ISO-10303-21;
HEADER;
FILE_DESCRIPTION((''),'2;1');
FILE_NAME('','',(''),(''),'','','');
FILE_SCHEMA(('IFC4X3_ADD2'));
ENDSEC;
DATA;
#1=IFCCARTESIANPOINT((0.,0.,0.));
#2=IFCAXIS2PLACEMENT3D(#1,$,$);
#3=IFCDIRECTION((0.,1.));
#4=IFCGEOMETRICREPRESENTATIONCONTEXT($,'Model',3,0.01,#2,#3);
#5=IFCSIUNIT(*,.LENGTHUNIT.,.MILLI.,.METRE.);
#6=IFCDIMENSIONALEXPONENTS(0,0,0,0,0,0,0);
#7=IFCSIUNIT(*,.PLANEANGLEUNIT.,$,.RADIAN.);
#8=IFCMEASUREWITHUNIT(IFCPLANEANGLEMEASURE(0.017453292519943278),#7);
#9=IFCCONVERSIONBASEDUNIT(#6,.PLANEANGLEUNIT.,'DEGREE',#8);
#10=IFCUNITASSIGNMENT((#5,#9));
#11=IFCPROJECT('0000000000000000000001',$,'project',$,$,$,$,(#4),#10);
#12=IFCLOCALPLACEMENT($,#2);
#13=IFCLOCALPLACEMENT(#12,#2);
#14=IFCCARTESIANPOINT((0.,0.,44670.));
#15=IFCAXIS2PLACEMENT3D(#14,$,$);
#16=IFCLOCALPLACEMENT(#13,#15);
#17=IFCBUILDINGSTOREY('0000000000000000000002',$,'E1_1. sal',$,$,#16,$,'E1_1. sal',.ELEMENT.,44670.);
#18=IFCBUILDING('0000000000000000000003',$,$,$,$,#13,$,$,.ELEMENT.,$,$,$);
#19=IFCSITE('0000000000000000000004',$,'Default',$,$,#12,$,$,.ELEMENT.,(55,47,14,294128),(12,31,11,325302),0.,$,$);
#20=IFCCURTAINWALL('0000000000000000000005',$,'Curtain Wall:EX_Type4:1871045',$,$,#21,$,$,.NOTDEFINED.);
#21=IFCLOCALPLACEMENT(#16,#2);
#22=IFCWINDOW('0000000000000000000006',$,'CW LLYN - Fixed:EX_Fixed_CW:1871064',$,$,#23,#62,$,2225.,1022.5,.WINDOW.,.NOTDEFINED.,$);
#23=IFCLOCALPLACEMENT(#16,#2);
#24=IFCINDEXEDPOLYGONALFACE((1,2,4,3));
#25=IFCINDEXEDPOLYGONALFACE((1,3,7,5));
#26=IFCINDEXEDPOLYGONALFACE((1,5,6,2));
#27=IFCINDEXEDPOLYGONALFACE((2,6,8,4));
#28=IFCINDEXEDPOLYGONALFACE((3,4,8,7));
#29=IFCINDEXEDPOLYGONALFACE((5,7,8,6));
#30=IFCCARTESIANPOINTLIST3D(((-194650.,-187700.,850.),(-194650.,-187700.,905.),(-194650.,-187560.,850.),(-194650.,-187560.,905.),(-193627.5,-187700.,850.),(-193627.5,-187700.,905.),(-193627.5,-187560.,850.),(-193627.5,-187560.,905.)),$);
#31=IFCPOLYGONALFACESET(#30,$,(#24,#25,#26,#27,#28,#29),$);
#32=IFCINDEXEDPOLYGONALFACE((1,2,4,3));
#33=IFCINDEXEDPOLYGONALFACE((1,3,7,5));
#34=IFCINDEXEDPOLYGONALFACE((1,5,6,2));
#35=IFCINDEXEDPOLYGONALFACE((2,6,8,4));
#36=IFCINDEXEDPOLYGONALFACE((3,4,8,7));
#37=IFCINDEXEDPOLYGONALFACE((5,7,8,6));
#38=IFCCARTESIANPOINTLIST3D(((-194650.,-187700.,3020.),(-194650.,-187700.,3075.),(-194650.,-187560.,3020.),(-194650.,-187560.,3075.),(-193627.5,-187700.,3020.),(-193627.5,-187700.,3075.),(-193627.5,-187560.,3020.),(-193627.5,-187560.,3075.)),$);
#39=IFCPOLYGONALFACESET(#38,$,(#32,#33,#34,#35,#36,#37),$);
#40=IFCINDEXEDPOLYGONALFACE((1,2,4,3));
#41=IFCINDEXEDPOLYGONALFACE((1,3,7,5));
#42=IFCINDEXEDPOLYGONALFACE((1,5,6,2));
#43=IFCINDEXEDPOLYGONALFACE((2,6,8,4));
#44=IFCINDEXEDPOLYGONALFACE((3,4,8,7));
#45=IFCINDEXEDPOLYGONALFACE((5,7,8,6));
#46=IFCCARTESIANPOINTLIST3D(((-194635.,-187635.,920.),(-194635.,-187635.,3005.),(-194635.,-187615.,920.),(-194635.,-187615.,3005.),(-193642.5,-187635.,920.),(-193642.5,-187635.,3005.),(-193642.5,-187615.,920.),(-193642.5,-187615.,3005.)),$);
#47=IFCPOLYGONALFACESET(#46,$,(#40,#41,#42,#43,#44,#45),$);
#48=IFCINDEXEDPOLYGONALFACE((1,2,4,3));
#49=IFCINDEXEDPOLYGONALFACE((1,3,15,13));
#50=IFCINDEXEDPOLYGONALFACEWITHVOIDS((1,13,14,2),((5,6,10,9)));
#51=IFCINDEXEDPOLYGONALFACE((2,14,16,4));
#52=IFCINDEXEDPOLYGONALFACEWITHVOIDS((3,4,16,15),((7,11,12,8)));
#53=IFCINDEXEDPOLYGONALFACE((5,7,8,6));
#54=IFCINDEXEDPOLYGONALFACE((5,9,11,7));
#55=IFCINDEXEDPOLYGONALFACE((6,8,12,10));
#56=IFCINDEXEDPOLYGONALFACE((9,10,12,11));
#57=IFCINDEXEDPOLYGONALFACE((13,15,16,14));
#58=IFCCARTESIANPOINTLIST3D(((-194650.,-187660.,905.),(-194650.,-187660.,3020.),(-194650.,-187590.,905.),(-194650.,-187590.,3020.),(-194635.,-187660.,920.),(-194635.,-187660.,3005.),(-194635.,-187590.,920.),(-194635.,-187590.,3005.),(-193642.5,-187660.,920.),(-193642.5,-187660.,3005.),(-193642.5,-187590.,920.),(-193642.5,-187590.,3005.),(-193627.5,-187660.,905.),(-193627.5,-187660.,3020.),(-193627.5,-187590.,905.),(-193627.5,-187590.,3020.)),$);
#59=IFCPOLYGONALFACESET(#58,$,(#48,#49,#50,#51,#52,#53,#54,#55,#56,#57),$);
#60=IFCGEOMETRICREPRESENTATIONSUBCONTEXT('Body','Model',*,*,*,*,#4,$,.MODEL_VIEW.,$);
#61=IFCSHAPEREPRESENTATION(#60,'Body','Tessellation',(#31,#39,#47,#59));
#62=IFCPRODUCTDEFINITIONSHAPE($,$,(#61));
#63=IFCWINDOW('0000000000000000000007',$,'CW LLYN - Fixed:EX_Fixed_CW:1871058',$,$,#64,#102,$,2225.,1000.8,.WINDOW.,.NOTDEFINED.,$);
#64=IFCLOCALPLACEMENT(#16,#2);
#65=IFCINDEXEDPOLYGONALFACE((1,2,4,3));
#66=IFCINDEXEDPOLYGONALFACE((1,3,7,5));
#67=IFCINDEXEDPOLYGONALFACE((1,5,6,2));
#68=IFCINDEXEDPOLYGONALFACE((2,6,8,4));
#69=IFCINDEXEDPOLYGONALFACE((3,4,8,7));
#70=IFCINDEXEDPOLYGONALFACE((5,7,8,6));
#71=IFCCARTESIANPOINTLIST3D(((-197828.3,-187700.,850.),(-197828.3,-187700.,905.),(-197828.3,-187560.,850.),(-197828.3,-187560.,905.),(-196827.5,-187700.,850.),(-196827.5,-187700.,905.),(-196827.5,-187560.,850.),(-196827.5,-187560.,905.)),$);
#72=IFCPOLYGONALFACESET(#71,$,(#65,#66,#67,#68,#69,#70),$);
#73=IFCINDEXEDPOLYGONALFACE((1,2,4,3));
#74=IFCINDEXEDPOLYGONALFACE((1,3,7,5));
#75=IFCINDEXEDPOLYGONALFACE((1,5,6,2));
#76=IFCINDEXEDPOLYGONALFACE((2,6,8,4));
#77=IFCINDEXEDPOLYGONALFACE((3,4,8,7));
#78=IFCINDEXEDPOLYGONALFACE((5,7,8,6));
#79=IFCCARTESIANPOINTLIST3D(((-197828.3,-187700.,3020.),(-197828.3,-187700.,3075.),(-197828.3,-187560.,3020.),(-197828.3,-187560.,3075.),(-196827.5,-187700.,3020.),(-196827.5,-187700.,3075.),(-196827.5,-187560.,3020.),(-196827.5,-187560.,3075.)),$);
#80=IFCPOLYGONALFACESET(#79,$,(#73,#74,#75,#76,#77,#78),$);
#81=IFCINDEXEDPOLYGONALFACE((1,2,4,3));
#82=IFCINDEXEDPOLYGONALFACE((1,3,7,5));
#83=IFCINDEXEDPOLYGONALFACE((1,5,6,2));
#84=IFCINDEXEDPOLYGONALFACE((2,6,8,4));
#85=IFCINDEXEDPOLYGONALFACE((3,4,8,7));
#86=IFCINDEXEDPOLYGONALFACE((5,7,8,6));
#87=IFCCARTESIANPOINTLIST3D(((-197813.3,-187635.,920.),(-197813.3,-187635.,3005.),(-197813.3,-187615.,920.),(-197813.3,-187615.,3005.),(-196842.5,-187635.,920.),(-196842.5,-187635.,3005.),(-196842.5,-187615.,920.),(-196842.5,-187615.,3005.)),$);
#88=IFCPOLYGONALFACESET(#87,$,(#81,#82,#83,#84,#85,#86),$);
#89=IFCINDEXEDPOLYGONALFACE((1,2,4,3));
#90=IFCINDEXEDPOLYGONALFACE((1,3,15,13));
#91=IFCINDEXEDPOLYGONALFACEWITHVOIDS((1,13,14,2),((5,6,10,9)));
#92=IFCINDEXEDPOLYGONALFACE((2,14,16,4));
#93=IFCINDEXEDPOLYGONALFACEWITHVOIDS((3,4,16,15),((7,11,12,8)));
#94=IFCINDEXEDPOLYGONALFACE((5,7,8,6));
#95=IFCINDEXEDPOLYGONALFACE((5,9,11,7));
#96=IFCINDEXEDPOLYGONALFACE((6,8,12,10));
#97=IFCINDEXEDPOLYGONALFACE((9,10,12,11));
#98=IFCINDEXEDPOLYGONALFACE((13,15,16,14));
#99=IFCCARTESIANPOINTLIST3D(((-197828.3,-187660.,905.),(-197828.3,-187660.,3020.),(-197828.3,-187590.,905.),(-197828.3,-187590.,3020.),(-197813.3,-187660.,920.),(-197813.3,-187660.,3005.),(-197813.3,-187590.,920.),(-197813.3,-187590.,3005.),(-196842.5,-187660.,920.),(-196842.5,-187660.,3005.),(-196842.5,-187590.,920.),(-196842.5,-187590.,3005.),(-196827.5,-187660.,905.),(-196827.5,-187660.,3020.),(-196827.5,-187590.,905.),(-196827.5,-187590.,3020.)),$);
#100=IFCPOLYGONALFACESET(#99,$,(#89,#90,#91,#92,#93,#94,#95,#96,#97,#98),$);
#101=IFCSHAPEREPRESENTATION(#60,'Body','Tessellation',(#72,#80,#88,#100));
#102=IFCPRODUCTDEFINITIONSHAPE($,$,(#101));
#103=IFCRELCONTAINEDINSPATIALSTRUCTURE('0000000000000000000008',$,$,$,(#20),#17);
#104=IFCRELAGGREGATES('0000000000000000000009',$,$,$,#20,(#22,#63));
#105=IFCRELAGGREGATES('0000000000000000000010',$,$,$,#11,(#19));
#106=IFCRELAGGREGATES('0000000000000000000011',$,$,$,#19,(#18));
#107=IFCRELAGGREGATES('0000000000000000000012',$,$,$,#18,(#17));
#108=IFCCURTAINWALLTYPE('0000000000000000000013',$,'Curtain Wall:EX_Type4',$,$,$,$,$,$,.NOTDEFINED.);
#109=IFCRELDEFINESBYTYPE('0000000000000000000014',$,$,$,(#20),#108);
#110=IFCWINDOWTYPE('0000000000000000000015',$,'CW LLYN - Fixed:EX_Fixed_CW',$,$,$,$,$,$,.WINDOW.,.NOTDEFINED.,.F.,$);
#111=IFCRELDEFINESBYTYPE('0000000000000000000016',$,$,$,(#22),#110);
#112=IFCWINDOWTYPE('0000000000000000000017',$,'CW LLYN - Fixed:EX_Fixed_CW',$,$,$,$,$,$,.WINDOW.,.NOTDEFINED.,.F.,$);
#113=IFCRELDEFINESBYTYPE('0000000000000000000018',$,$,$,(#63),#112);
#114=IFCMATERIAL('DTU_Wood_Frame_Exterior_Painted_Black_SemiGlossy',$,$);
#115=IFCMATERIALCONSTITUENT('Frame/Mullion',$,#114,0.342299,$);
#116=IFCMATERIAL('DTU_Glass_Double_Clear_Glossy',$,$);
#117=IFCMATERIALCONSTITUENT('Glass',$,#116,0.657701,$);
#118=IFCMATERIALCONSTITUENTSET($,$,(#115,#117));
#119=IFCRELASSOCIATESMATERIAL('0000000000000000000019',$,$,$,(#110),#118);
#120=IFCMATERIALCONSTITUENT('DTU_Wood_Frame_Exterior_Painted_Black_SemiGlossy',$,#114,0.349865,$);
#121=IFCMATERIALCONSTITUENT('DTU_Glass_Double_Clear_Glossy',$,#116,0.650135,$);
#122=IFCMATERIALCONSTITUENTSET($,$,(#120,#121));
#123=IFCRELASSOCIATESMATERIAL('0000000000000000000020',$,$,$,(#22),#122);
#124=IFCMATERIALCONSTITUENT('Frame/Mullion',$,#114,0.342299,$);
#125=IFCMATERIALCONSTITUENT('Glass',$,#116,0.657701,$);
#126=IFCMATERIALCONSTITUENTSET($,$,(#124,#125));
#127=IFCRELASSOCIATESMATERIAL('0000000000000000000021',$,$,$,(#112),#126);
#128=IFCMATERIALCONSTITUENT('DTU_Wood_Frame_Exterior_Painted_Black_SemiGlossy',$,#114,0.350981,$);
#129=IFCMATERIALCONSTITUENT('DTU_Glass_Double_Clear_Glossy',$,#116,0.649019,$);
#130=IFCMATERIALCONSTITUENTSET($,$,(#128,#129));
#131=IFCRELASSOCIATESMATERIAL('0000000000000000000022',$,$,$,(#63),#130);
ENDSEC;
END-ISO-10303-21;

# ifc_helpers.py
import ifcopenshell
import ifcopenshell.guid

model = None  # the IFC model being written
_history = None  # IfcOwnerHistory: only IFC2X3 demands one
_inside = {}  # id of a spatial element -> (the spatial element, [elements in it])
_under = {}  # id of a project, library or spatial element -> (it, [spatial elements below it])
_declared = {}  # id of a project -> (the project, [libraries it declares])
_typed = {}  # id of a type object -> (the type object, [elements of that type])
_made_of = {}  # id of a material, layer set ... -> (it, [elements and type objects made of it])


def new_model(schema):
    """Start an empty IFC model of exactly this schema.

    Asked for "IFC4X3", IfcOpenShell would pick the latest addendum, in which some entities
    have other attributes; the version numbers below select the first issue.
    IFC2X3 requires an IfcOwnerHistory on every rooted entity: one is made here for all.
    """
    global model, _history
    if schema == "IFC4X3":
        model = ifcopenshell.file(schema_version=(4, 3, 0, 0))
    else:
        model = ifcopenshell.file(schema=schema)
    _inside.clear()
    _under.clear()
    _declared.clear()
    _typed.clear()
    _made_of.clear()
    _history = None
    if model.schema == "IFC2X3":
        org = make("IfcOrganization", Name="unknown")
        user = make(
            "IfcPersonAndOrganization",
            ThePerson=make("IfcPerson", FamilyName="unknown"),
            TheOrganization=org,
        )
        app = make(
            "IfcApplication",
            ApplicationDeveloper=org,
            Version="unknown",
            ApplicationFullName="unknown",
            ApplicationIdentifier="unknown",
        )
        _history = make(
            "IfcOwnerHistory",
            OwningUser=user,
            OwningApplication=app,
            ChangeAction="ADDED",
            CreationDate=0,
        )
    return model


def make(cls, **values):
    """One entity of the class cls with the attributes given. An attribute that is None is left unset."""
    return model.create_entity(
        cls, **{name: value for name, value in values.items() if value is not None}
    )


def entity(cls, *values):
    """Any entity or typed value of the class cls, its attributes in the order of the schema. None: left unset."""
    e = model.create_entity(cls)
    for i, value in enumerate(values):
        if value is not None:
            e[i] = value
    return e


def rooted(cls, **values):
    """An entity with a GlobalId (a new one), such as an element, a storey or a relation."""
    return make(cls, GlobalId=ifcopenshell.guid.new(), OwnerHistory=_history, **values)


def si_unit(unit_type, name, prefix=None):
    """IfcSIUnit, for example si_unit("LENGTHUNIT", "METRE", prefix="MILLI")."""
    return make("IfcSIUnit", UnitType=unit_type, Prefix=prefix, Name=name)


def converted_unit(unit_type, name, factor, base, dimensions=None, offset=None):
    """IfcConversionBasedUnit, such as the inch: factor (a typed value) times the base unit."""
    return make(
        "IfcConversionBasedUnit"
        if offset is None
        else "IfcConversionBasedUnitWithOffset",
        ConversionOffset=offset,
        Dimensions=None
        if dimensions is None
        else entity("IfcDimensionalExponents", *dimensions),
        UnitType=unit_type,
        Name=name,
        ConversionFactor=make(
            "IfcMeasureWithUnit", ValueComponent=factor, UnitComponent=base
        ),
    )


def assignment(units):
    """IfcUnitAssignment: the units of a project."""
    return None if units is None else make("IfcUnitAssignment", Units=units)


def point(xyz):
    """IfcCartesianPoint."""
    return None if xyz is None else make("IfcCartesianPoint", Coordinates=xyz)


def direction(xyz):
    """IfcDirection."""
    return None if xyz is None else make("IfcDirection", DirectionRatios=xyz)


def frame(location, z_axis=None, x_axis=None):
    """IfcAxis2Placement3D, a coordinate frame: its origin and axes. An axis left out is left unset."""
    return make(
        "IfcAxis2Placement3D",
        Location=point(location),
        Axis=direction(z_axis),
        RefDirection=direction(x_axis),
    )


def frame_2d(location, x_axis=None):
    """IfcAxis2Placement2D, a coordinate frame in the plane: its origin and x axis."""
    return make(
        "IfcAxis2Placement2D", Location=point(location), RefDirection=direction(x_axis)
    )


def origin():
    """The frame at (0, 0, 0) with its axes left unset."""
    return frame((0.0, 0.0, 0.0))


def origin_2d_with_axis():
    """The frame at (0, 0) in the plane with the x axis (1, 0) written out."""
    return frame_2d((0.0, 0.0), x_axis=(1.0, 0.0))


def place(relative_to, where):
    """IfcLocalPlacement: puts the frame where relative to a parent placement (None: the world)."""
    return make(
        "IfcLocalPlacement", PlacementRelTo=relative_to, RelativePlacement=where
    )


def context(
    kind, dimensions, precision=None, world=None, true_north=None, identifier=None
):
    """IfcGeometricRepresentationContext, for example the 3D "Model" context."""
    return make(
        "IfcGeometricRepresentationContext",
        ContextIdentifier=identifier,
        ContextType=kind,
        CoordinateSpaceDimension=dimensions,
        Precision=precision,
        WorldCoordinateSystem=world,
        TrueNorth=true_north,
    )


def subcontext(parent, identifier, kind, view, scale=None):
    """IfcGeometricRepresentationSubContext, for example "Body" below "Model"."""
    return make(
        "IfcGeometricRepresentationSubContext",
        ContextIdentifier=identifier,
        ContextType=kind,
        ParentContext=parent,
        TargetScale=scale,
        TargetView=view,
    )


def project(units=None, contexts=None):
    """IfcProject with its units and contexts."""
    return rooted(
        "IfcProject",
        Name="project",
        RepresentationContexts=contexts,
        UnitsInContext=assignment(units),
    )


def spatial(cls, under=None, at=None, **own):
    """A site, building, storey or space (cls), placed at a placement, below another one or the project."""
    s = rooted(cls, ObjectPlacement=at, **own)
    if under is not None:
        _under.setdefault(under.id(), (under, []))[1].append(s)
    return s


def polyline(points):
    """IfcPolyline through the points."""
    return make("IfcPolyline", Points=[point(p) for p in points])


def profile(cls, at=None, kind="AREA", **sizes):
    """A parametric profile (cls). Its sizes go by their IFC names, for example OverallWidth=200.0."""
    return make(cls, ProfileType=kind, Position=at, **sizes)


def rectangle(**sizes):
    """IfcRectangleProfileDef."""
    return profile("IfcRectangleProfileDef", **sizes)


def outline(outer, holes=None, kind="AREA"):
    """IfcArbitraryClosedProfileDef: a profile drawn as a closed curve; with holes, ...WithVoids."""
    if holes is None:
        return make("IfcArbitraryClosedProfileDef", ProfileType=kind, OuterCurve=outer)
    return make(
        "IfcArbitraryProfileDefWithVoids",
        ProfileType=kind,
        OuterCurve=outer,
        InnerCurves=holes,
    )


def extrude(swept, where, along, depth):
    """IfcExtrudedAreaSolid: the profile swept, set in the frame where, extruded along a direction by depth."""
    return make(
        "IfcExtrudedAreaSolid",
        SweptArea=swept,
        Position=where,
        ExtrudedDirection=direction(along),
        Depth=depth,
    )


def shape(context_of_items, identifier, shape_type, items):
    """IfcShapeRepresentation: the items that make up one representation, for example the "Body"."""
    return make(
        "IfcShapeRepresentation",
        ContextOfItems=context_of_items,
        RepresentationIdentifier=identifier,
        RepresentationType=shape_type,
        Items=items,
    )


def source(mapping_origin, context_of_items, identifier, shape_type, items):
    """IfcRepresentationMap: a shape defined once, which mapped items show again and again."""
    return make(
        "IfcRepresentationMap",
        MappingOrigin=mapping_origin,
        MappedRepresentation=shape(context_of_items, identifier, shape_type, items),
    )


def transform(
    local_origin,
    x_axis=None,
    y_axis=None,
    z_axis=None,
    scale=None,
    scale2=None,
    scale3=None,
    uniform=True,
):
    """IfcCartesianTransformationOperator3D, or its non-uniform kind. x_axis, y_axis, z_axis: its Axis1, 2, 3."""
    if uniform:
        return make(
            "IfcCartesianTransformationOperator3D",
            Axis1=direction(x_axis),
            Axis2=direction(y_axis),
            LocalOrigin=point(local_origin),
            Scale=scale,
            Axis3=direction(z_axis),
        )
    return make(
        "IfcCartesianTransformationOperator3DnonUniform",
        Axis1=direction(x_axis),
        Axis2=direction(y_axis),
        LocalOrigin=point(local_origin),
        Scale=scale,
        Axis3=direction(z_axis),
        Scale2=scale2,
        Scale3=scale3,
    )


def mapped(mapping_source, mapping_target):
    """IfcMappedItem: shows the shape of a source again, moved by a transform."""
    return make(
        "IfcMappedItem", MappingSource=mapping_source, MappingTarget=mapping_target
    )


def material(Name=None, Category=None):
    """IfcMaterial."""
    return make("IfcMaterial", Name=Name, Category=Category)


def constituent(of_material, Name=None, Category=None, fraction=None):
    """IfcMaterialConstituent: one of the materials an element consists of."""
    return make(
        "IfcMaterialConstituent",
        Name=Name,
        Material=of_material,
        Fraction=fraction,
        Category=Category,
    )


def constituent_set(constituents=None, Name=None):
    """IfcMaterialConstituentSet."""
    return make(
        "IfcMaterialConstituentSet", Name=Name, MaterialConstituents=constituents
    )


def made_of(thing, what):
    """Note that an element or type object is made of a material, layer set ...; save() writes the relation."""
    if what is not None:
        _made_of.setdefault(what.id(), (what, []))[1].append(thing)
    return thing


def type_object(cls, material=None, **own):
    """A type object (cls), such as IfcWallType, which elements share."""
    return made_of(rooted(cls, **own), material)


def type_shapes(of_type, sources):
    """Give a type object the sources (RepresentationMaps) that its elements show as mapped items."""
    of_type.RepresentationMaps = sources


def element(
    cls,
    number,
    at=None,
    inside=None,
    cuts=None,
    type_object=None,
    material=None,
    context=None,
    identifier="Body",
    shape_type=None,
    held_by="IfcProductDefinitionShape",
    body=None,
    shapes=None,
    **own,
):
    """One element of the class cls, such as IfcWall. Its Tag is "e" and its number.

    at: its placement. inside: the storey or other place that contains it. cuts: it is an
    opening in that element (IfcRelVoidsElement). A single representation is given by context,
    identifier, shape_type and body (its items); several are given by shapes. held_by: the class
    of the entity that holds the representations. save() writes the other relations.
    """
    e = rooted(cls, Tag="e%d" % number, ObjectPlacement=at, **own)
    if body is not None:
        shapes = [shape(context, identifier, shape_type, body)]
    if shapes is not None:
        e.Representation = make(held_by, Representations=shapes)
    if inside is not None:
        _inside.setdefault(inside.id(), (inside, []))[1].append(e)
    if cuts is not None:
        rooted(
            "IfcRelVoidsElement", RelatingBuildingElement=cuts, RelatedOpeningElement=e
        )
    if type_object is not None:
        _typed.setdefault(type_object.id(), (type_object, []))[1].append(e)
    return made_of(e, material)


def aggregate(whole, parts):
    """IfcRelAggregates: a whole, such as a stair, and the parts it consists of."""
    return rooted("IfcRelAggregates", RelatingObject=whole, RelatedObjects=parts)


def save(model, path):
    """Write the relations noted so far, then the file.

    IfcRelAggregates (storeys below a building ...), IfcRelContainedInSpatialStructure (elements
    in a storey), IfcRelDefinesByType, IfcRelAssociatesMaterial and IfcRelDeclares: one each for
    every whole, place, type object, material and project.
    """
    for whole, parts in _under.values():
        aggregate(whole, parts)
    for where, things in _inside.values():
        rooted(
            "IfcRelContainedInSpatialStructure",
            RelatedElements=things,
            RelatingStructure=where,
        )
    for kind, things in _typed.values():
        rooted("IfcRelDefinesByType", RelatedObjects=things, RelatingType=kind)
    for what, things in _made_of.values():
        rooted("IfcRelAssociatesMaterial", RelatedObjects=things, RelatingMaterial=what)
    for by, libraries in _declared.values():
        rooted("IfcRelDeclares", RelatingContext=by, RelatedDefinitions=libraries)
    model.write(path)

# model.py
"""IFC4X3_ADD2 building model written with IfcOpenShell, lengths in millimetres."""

from ifc_helpers import new_model, entity, si_unit, converted_unit, direction, frame, frame_2d, origin, origin_2d_with_axis, place, context, subcontext, project, spatial, polyline, rectangle, outline, extrude, source, transform, mapped, material, constituent, constituent_set, type_object, type_shapes, element, aggregate, save


model = new_model("IFC4X3_ADD2")

# Units and contexts
model_context = context("Model", 3, precision=0.01, world=origin(), true_north=direction((0.0, 1.0)))
body_context = subcontext(model_context, "Body", "Model", "MODEL_VIEW")
ifc_project = project(units=[si_unit("LENGTHUNIT", "METRE", prefix="MILLI"), converted_unit("PLANEANGLEUNIT", "DEGREE", entity("IfcPlaneAngleMeasure", 0.017453292519943278), si_unit("PLANEANGLEUNIT", "RADIAN"), dimensions=[0, 0, 0, 0, 0, 0, 0])], contexts=[model_context])

# Site, building, storey
site_placement = place(None, origin())
site = spatial("IfcSite", under=ifc_project, at=site_placement, Name="Default", CompositionType="ELEMENT", RefLatitude=(55, 47, 14, 294128), RefLongitude=(12, 31, 11, 325302), RefElevation=0.0)
building_placement = place(site_placement, origin())
building = spatial("IfcBuilding", under=site, at=building_placement, CompositionType="ELEMENT")
storey_placement = place(building_placement, frame((0.0, 0.0, 44670.0)))
storey = spatial("IfcBuildingStorey", under=building, at=storey_placement, Name="E1_1. sal", LongName="E1_1. sal", CompositionType="ELEMENT", Elevation=44670.0)

# Curtain wall, windows
curtain_wall_type = type_object("IfcCurtainWallType", Name="Curtain Wall:EX_Type4", PredefinedType="NOTDEFINED")
curtain_wall_placement = place(storey_placement, frame((0.0, 0.0, -44670.0)))
curtain_wall = element("IfcCurtainWall", 1, at=curtain_wall_placement, inside=storey, type_object=curtain_wall_type, Name="Curtain Wall:EX_Type4:1871045", PredefinedType="NOTDEFINED")
ifc_material_1 = material(Name="DTU_Wood_Frame_Exterior_Painted_Black_SemiGlossy")
ifc_material_2 = material(Name="DTU_Glass_Double_Clear_Glossy")
ifc_constituent_1 = constituent(ifc_material_1, Name="DTU_Wood_Frame_Exterior_Painted_Black_SemiGlossy", fraction=0.349865)
ifc_constituent_2 = constituent(ifc_material_2, Name="DTU_Glass_Double_Clear_Glossy", fraction=0.650135)
ifc_constituent_set_1 = constituent_set(constituents=[ifc_constituent_1, ifc_constituent_2])
ifc_constituent_3 = constituent(ifc_material_1, Name="Frame/Mullion", fraction=0.342299)
ifc_constituent_4 = constituent(ifc_material_2, Name="Glass", fraction=0.657701)
ifc_constituent_set_2 = constituent_set(constituents=[ifc_constituent_3, ifc_constituent_4])
window_type_1 = type_object("IfcWindowType", Name="CW LLYN - Fixed:EX_Fixed_CW", ParameterTakesPrecedence=False, PartitioningType="NOTDEFINED", PredefinedType="WINDOW", material=ifc_constituent_set_2)
shared_shape_1 = source(origin(), body_context, "Body", "SweptSolid", [
    extrude(rectangle(XDim=140.0, YDim=1022.5, at=origin_2d_with_axis()), frame((0.0, -130.0, 0.0), z_axis=(0.0, 0.0, 1.0), x_axis=(0.0, -1.0, 0.0)), (0.0, 0.0, 1.0), 55.0),
    extrude(rectangle(XDim=140.0, YDim=1022.5, at=frame_2d((0.0, 0.0), x_axis=(1.0, 0.0))), frame((0.0, -130.0, 2170.0), z_axis=(0.0, 0.0, 1.0), x_axis=(0.0, -1.0, 0.0)), (0.0, 0.0, 1.0), 55.0),
    extrude(rectangle(XDim=992.5, YDim=20.0, at=frame_2d((0.0, 0.0), x_axis=(1.0, 0.0))), frame((0.0, -125.0, 70.0), z_axis=(0.0, 0.0, 1.0), x_axis=(-1.0, 0.0, 0.0)), (0.0, 0.0, 1.0), 2085.0),
    extrude(outline(polyline([(-1057.5, -511.3), (1057.5, -511.3), (1057.5, 511.3), (-1057.5, 511.3), (-1057.5, -511.3)]), holes=[polyline([(-1042.5, 496.3), (1042.5, 496.3), (1042.5, -496.3), (-1042.5, -496.3), (-1042.5, 496.3)])]), frame((0.0, -90.0, 1112.5), z_axis=(0.0, -1.0, 0.0), x_axis=(0.0, 0.0, 1.0)), (0.0, 0.0, 1.0), 70.0),
])
type_shapes(window_type_1, [shared_shape_1])
window_1_placement = place(curtain_wall_placement, frame((-194138.7, -187500.0, 45520.0)))
window_1 = element("IfcWindow", 2, at=window_1_placement, type_object=window_type_1, material=ifc_constituent_set_1, Name="CW LLYN - Fixed:EX_Fixed_CW:1871064", OverallHeight=2225.0, OverallWidth=1022.5, PartitioningType="NOTDEFINED", PredefinedType="WINDOW", context=body_context, shape_type="MappedRepresentation", body=[
    mapped(shared_shape_1, transform((0.0, 0.0, 0.0), scale=1.0)),
])
ifc_constituent_5 = constituent(ifc_material_1, Name="DTU_Wood_Frame_Exterior_Painted_Black_SemiGlossy", fraction=0.350981)
ifc_constituent_6 = constituent(ifc_material_2, Name="DTU_Glass_Double_Clear_Glossy", fraction=0.649019)
ifc_constituent_set_3 = constituent_set(constituents=[ifc_constituent_5, ifc_constituent_6])
ifc_constituent_7 = constituent(ifc_material_1, Name="Frame/Mullion", fraction=0.342299)
ifc_constituent_8 = constituent(ifc_material_2, Name="Glass", fraction=0.657701)
ifc_constituent_set_4 = constituent_set(constituents=[ifc_constituent_7, ifc_constituent_8])
window_type_2 = type_object("IfcWindowType", Name="CW LLYN - Fixed:EX_Fixed_CW", ParameterTakesPrecedence=False, PartitioningType="NOTDEFINED", PredefinedType="WINDOW", material=ifc_constituent_set_4)
shared_shape_2 = source(origin(), body_context, "Body", "SweptSolid", [
    extrude(rectangle(XDim=140.0, YDim=1000.8, at=frame_2d((0.0, 0.0), x_axis=(1.0, 0.0))), frame((0.0, -130.0, 0.0), z_axis=(0.0, 0.0, 1.0), x_axis=(0.0, -1.0, 0.0)), (0.0, 0.0, 1.0), 55.0),
    extrude(rectangle(XDim=140.0, YDim=1000.8, at=frame_2d((0.0, 0.0), x_axis=(1.0, 0.0))), frame((0.0, -130.0, 2170.0), z_axis=(0.0, 0.0, 1.0), x_axis=(0.0, -1.0, 0.0)), (0.0, 0.0, 1.0), 55.0),
    extrude(rectangle(XDim=970.8, YDim=20.0, at=frame_2d((0.0, 0.0), x_axis=(1.0, 0.0))), frame((0.0, -125.0, 70.0), z_axis=(0.0, 0.0, 1.0), x_axis=(-1.0, 0.0, 0.0)), (0.0, 0.0, 1.0), 2085.0),
    extrude(outline(polyline([(-1057.5, -500.4), (1057.5, -500.4), (1057.5, 500.4), (-1057.5, 500.4), (-1057.5, -500.4)]), holes=[polyline([(-1042.5, 485.4), (1042.5, 485.4), (1042.5, -485.4), (-1042.5, -485.4), (-1042.5, 485.4)])]), frame((0.0, -90.0, 1112.5), z_axis=(0.0, -1.0, 0.0), x_axis=(0.0, 0.0, 1.0)), (0.0, 0.0, 1.0), 70.0),
])
type_shapes(window_type_2, [shared_shape_2])
window_2_placement = place(curtain_wall_placement, frame((-197327.9, -187500.0, 45520.0)))
window_2 = element("IfcWindow", 3, at=window_2_placement, type_object=window_type_2, material=ifc_constituent_set_3, Name="CW LLYN - Fixed:EX_Fixed_CW:1871058", OverallHeight=2225.0, OverallWidth=1000.8, PartitioningType="NOTDEFINED", PredefinedType="WINDOW", context=body_context, shape_type="MappedRepresentation", body=[
    mapped(shared_shape_2, transform((0.0, 0.0, 0.0), scale=1.0)),
])
aggregate(curtain_wall, [window_1, window_2])

save(model, "model.ifc")
